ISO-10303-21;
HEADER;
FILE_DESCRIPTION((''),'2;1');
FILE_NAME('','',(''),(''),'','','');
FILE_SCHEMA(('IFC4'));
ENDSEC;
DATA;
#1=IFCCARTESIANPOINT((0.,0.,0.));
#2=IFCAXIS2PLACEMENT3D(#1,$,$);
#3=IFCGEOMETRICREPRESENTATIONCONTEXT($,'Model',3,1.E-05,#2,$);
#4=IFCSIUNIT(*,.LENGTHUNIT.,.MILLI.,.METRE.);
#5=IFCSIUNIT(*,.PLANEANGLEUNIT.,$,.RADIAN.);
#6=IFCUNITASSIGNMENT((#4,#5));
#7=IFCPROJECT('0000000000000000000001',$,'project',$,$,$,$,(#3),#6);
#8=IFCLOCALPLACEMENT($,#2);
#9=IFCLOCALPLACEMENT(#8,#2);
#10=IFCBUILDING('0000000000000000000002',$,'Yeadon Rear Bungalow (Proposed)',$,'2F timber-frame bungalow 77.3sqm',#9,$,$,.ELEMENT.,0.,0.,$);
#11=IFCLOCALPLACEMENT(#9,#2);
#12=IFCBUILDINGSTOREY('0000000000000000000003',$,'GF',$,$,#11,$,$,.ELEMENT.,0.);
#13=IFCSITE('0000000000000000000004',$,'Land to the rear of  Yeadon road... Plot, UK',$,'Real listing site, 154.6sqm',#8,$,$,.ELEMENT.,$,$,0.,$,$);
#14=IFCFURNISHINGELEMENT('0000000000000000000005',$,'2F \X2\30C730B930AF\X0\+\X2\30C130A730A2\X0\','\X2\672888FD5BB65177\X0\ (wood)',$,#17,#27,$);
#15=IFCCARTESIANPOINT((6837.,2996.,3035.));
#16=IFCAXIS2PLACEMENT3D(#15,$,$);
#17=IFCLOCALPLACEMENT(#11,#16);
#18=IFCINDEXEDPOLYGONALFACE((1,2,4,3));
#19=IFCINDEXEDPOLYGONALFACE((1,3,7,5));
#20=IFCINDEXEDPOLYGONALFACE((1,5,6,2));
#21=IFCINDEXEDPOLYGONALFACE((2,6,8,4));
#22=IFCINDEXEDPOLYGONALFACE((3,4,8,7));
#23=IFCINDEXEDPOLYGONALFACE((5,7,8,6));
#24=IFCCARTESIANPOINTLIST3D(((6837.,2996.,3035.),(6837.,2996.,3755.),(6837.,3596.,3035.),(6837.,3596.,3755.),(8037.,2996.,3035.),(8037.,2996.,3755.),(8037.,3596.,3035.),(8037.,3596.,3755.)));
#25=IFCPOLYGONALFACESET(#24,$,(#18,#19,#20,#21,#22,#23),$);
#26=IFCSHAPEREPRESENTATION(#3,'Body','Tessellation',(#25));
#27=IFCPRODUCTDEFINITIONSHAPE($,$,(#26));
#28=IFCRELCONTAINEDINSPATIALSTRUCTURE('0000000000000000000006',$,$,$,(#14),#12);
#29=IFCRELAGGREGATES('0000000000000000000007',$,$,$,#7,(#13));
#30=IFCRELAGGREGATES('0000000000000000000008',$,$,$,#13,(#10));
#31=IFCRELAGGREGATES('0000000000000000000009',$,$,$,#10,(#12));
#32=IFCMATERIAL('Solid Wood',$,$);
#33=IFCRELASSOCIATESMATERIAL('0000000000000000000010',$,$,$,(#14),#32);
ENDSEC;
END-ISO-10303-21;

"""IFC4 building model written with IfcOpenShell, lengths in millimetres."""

from ifc_helpers import new_model, si_unit, frame, frame_2d, origin, place, context, project, spatial, rectangle, extrude, material, element, save


model = new_model("IFC4")

# Units and contexts
model_context = context("Model", 3, precision=1e-05, world=origin())
ifc_project = project(units=[si_unit("LENGTHUNIT", "METRE", prefix="MILLI"), si_unit("PLANEANGLEUNIT", "RADIAN")], contexts=[model_context])

# Site, building, storey
site_placement = place(None, origin())
site = spatial("IfcSite", under=ifc_project, at=site_placement, Name="Land to the rear of  Yeadon road... Plot, UK", ObjectType="Real listing site, 154.6sqm", CompositionType="ELEMENT", RefElevation=0.0)
building_placement = place(site_placement, origin())
building = spatial("IfcBuilding", under=site, at=building_placement, Name="Yeadon Rear Bungalow (Proposed)", ObjectType="2F timber-frame bungalow 77.3sqm", CompositionType="ELEMENT", ElevationOfRefHeight=0.0, ElevationOfTerrain=0.0)
storey_placement = place(building_placement, origin())
storey = spatial("IfcBuildingStorey", under=building, at=storey_placement, Name="GF", CompositionType="ELEMENT", Elevation=0.0)

# Shared definitions
ifc_material_1 = material(Name="Solid Wood")

# Furnishing element
furnishing_1_placement = place(storey_placement, frame((6837.0, 2996.0, 3035.0)))
element("IfcFurnishingElement", 1, at=furnishing_1_placement, inside=storey, material=ifc_material_1, Name="2F デスク+チェア", Description="木製家具 (wood)", context=model_context, shape_type="SweptSolid", body=[
    extrude(rectangle(XDim=1200.0, YDim=600.0, at=frame_2d((600.0, 300.0))), frame((6837.0, 2996.0, 3035.0)), (0.0, 0.0, 1.0), 720.0),
])

save(model, "model.ifc")
